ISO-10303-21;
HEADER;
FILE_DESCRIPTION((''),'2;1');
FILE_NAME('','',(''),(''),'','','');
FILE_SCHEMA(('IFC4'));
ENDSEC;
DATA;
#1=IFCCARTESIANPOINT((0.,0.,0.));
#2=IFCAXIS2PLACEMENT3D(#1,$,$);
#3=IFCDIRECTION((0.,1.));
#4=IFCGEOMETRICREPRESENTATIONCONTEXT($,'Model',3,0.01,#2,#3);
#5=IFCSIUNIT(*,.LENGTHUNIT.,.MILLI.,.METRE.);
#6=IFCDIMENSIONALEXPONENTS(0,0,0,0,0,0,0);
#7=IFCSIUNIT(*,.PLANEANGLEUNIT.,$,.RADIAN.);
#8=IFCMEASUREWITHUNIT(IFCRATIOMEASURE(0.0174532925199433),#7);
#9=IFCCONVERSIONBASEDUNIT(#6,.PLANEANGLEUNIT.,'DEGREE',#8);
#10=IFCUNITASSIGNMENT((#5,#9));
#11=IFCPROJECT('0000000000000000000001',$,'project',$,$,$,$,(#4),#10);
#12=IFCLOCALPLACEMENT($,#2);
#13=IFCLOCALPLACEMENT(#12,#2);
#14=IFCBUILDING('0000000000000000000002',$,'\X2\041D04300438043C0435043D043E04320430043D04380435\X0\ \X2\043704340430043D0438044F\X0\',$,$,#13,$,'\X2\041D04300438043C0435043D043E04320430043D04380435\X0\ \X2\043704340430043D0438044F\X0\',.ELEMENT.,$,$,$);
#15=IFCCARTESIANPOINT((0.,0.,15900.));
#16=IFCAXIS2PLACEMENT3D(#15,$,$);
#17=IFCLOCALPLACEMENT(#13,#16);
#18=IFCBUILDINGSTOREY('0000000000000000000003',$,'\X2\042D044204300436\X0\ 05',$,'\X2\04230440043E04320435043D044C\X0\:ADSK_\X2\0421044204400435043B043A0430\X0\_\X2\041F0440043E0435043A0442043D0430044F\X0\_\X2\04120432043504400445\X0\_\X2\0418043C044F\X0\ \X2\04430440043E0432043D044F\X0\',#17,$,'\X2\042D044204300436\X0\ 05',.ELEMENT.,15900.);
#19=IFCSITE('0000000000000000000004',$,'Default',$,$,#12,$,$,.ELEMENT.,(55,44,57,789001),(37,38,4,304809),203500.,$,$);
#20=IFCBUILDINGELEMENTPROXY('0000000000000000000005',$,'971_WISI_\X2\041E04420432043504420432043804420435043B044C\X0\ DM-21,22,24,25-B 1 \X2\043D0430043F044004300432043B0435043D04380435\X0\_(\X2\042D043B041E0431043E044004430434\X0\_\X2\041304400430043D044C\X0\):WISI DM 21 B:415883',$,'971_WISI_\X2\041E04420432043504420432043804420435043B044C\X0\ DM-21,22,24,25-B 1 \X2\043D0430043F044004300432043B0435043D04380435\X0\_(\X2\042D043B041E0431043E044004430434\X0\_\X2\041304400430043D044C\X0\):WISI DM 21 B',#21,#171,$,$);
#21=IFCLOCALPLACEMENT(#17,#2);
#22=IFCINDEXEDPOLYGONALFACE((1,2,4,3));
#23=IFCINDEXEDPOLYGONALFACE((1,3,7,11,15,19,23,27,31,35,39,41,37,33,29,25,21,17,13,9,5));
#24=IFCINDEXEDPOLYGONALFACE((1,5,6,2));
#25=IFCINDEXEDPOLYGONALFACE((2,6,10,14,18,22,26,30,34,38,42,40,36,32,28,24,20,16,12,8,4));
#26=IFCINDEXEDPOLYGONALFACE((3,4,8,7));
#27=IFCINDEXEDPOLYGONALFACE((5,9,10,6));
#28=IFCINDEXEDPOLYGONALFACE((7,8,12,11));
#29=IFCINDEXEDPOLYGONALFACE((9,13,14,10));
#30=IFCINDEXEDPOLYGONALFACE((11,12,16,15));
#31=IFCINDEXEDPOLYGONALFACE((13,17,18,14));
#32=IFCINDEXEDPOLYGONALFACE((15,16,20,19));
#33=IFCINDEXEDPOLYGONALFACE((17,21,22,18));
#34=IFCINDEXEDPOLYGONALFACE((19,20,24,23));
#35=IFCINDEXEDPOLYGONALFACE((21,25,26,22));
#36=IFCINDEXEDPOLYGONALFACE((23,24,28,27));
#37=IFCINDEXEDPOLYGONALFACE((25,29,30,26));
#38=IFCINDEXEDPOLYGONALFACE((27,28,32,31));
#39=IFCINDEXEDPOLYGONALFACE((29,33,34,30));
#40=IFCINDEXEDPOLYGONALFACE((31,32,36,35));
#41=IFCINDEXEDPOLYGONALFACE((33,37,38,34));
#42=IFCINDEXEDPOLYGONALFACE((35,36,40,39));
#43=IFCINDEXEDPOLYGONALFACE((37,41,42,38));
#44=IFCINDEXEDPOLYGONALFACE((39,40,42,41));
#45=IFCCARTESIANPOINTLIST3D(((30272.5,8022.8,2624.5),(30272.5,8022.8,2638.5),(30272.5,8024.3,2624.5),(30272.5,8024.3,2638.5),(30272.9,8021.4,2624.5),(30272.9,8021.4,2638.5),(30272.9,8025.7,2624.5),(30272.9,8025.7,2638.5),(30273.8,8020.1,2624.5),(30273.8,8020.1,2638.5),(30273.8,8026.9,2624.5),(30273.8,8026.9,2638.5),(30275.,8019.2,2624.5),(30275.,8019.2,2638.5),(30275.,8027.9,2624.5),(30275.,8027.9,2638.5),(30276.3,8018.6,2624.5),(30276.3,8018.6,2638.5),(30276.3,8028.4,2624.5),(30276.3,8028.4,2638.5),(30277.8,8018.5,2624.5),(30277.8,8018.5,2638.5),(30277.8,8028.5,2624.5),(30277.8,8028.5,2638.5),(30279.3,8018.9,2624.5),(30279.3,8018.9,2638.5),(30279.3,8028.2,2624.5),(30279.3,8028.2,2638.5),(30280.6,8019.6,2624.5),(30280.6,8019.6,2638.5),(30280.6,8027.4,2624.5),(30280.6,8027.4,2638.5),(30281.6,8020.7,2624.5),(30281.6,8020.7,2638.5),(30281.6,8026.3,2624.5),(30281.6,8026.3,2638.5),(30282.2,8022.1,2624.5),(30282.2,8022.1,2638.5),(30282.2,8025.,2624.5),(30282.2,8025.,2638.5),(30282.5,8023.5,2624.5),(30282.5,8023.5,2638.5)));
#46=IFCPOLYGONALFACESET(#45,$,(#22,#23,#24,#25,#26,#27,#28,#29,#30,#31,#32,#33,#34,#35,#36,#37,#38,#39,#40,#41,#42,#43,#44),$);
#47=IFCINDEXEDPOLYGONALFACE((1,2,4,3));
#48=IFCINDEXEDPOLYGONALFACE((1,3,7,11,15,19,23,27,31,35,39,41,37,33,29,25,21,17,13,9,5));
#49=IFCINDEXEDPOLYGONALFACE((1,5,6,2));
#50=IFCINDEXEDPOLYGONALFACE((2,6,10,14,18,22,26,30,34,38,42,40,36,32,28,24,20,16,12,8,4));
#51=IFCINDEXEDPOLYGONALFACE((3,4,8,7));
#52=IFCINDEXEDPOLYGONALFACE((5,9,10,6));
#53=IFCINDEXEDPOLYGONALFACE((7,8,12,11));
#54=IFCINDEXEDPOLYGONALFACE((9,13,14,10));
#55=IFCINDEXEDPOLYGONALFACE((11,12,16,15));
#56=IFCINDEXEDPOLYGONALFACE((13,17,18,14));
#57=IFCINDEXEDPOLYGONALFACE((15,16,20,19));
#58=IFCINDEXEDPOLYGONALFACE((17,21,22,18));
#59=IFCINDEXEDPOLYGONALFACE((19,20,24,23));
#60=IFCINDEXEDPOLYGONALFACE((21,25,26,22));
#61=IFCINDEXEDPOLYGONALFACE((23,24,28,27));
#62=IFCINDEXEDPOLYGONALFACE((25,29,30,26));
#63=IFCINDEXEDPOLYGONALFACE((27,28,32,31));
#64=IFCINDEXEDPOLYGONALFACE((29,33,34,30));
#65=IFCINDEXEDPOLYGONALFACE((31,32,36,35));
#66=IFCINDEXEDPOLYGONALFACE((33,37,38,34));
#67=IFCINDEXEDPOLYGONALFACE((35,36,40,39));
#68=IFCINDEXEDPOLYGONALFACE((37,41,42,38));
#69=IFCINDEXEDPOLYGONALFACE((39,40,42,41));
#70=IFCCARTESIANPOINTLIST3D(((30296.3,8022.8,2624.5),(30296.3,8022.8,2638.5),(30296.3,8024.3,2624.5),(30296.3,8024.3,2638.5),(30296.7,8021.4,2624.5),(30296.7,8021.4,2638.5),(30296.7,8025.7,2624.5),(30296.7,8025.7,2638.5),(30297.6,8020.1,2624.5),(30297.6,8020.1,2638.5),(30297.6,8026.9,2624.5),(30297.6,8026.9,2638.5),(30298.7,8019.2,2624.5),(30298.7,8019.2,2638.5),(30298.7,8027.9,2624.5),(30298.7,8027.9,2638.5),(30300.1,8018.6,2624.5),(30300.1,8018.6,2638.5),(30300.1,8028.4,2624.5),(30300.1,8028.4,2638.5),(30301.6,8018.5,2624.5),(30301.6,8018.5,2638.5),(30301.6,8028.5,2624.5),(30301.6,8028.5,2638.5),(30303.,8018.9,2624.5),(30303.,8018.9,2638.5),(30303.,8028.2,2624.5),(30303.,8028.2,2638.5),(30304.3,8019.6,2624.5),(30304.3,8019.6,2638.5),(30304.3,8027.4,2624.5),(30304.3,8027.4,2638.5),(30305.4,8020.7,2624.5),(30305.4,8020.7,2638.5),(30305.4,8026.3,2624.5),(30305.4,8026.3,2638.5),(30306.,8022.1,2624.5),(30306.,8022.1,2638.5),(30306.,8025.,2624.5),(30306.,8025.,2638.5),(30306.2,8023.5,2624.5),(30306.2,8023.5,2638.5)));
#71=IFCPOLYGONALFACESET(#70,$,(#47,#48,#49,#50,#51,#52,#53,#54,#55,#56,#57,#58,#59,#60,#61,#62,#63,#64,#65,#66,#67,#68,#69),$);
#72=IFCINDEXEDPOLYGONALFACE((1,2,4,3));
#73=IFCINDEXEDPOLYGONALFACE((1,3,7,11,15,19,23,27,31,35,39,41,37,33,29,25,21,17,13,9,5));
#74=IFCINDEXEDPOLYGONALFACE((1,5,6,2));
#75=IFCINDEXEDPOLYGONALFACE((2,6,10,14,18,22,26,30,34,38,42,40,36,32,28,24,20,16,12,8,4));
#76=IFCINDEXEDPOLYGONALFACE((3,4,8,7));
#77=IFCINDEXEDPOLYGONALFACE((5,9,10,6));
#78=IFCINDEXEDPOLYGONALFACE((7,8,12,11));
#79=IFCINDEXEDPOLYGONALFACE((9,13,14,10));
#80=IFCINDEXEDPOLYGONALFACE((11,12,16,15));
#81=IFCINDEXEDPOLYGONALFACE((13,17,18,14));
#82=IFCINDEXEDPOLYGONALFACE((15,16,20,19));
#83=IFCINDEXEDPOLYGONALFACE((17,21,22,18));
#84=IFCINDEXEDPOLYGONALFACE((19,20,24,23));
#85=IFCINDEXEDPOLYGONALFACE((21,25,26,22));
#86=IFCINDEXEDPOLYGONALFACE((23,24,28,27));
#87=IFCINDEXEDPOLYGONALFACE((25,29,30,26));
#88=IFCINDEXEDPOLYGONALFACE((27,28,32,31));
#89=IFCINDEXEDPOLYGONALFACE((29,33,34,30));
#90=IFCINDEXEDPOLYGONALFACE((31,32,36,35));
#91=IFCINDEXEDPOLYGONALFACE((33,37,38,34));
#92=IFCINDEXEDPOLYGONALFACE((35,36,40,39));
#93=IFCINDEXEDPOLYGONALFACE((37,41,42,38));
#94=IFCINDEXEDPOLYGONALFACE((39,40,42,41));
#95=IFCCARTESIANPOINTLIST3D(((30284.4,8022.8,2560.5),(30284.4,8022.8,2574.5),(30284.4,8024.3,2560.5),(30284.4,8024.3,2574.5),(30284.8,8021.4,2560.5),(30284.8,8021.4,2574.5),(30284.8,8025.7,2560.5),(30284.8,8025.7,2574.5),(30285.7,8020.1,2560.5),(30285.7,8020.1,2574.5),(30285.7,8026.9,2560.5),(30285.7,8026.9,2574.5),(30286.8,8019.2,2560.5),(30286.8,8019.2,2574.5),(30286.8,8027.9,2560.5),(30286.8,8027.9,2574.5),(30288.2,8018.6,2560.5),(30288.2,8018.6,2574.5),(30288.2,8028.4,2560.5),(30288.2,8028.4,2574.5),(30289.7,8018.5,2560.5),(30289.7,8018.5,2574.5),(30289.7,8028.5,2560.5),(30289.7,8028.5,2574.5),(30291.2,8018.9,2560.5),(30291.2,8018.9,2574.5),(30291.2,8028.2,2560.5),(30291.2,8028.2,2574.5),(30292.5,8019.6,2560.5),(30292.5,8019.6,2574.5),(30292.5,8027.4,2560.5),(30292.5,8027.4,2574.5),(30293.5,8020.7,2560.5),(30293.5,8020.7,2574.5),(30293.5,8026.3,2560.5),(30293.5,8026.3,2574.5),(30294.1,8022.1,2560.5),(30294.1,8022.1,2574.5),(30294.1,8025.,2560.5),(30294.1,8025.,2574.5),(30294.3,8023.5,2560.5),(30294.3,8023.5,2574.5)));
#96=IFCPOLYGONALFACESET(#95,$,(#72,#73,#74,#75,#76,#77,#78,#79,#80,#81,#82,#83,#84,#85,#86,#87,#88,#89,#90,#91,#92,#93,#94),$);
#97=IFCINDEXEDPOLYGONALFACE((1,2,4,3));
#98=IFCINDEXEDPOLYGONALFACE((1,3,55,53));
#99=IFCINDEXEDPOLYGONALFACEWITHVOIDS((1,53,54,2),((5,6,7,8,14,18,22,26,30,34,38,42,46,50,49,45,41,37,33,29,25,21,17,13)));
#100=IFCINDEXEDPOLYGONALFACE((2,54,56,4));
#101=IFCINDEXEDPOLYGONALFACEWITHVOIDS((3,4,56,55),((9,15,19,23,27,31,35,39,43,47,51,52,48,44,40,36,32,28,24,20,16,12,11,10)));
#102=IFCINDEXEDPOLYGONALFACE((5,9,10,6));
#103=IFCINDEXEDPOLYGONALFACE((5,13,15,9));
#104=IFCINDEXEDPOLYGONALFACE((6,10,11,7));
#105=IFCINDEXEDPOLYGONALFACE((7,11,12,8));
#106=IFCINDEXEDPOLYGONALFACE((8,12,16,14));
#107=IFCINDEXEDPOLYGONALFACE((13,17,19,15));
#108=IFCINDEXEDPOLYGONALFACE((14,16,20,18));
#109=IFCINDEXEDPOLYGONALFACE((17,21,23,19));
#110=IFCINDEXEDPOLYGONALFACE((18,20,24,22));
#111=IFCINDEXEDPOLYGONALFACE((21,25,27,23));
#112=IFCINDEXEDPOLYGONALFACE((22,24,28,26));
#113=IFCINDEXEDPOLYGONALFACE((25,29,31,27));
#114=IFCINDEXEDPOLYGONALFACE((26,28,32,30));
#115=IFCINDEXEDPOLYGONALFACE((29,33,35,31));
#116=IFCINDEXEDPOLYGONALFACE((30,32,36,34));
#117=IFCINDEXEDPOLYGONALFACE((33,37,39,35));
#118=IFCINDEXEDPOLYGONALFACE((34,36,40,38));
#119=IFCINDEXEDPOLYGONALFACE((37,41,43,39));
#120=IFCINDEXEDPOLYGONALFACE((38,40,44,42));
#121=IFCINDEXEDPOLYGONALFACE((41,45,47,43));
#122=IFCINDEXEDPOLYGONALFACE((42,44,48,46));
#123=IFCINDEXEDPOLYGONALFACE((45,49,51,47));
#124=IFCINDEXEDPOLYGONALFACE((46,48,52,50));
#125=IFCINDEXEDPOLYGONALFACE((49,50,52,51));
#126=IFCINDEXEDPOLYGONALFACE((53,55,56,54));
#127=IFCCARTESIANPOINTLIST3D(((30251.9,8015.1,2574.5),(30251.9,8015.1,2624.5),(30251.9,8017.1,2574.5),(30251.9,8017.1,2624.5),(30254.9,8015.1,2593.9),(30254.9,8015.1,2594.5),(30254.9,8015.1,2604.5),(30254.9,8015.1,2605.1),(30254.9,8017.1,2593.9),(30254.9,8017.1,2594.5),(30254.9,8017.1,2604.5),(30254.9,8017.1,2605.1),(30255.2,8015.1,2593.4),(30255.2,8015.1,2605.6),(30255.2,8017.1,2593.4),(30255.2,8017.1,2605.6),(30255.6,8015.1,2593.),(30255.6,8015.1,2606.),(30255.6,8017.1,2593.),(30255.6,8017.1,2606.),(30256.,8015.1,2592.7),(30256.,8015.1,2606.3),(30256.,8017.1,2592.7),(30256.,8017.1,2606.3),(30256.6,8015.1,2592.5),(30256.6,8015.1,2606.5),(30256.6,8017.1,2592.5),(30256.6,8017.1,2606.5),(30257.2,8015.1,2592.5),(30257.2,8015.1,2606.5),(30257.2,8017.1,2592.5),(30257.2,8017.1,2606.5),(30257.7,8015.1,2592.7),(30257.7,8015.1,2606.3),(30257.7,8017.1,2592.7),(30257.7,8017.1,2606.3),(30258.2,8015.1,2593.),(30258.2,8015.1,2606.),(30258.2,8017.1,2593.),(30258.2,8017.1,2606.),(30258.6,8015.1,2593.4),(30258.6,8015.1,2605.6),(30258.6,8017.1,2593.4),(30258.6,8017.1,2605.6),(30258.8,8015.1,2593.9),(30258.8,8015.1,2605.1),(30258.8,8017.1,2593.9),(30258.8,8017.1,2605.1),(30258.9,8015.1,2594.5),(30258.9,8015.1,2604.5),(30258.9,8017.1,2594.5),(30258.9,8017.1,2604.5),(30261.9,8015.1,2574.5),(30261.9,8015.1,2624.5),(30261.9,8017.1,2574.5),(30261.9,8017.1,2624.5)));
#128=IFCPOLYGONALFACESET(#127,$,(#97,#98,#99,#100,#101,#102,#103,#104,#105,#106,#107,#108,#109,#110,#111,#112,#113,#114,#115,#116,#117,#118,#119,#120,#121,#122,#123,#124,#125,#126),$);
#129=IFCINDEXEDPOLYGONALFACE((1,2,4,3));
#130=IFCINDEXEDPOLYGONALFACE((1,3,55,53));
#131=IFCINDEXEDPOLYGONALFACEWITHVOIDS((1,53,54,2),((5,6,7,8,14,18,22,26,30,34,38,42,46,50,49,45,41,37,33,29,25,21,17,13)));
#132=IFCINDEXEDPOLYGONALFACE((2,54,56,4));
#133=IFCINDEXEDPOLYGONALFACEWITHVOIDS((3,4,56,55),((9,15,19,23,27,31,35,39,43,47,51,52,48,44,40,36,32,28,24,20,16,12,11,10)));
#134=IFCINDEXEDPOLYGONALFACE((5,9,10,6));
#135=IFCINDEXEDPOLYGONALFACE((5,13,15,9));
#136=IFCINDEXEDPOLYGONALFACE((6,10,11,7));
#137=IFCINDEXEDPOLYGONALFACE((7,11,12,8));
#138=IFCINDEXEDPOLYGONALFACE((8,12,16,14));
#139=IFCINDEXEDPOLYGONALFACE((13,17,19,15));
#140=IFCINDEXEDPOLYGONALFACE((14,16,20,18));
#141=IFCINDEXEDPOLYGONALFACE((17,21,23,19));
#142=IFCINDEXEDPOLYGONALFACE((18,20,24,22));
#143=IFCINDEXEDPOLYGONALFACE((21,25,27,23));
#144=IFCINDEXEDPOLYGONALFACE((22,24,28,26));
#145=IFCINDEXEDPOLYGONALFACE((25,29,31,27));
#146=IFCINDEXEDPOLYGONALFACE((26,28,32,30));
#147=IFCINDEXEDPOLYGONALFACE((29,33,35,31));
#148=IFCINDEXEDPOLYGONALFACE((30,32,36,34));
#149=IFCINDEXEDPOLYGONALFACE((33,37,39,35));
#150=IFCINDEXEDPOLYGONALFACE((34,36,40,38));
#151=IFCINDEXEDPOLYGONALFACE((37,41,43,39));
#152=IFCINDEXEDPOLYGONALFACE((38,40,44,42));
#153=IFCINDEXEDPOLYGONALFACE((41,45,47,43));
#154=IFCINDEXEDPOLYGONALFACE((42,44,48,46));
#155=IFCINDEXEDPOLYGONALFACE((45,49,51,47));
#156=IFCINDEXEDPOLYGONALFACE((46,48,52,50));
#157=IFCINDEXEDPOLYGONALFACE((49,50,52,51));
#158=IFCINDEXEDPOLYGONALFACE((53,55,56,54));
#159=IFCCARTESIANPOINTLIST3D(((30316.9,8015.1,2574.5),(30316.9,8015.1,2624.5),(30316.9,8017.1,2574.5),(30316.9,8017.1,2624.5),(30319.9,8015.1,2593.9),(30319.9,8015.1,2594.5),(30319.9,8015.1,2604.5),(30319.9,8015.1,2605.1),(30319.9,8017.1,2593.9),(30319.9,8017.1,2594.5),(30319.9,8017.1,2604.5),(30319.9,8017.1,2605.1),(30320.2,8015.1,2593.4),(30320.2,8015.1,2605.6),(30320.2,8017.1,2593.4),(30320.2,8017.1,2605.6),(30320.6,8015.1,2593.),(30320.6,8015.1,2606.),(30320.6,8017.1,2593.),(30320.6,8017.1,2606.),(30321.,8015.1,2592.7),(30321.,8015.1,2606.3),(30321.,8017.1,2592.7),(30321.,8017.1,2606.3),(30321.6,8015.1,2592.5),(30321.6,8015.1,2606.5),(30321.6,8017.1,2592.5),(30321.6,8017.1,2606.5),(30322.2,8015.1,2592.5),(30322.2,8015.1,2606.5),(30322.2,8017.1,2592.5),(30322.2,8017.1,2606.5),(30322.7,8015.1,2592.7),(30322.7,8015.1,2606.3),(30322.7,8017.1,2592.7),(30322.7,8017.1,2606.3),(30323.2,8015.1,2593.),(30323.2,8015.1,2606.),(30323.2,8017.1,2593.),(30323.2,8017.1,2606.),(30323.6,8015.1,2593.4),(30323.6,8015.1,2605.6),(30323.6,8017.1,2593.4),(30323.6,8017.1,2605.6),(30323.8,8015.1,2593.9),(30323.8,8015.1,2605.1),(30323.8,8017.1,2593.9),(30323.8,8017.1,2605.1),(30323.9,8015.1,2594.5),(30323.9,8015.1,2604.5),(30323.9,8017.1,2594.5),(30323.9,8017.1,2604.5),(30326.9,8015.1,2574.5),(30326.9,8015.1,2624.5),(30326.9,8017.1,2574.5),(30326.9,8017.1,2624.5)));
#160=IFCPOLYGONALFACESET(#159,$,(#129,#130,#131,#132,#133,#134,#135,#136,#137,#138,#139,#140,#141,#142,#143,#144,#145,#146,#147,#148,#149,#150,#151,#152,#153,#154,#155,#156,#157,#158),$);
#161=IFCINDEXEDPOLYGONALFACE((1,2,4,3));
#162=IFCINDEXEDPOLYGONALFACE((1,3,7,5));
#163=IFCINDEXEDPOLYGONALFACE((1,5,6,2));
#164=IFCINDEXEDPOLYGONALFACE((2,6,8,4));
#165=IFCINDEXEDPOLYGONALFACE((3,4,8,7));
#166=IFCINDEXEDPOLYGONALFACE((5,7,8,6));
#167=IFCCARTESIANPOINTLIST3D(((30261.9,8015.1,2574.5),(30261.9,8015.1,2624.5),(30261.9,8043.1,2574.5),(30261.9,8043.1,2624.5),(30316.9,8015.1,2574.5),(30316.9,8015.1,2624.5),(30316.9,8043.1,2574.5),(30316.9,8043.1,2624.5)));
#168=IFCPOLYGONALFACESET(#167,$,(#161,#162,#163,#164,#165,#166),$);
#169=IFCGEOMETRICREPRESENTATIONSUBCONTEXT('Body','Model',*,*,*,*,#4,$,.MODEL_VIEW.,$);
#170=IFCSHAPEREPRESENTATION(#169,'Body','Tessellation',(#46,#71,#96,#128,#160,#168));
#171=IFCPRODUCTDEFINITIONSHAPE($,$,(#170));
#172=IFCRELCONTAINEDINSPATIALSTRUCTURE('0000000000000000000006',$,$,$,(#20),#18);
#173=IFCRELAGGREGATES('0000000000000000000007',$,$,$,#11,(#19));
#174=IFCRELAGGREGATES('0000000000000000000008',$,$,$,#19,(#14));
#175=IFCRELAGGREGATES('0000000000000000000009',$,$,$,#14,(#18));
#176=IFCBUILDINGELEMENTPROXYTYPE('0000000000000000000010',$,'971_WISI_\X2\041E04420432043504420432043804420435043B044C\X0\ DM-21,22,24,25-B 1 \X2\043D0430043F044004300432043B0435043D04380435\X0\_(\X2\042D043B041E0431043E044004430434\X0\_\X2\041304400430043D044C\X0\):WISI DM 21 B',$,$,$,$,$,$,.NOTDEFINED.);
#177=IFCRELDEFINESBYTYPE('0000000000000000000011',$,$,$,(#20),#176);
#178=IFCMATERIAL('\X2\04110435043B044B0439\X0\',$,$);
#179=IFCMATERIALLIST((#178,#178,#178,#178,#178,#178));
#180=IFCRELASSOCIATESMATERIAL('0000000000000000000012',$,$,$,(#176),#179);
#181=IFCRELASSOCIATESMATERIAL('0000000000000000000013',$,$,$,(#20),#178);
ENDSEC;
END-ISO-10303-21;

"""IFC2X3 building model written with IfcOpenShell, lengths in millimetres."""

from ifc_helpers import new_model, entity, si_unit, converted_unit, direction, frame, frame_2d, origin, place, context, subcontext, project, spatial, polyline, circle_curve, parameter, trimmed, segment, composite_curve, rectangle, circle, outline, extrude, source, transform, mapped, material, material_list, type_object, type_shapes, element, save


model = new_model("IFC2X3")

# Units and contexts
model_context = context("Model", 3, precision=0.01, world=origin(), true_north=direction((0.0, 1.0)))
body_context = subcontext(model_context, "Body", "Model", "MODEL_VIEW")
ifc_project = project(units=[si_unit("LENGTHUNIT", "METRE", prefix="MILLI"), converted_unit("PLANEANGLEUNIT", "DEGREE", entity("IfcRatioMeasure", 0.0174532925199433), si_unit("PLANEANGLEUNIT", "RADIAN"), dimensions=[0, 0, 0, 0, 0, 0, 0])], contexts=[model_context])

# Site, building, storey
site_placement = place(None, frame((0.0, 0.0, 0.0)))
site = spatial("IfcSite", under=ifc_project, at=site_placement, Name="Default", CompositionType="ELEMENT", RefLatitude=(55, 44, 57, 789001), RefLongitude=(37, 38, 4, 304809), RefElevation=203500.0)
building_placement = place(site_placement, origin())
building = spatial("IfcBuilding", under=site, at=building_placement, Name="Наименование здания", LongName="Наименование здания", CompositionType="ELEMENT")
storey_placement = place(building_placement, frame((0.0, 0.0, 15900.0)))
storey = spatial("IfcBuildingStorey", under=building, at=storey_placement, Name="Этаж 05", ObjectType="Уровень:ADSK_Стрелка_Проектная_Вверх_Имя уровня", LongName="Этаж 05", CompositionType="ELEMENT", Elevation=15900.0)

# Building element proxy
ifc_material = material(Name="Белый")
ifc_material_list = material_list([ifc_material, ifc_material, ifc_material, ifc_material, ifc_material, ifc_material])
building_element_proxy_type = type_object("IfcBuildingElementProxyType", Name="971_WISI_Ответвитель DM-21,22,24,25-B 1 направление_(ЭлОборуд_Грань):WISI DM 21 B", PredefinedType="NOTDEFINED", material=ifc_material_list)
shared_shape = source(origin(), body_context, "Body", "SweptSolid", [
    extrude(circle(Radius=5.0, at=frame_2d((0.0, 0.0), x_axis=(1.0, 0.0))), frame((11.9, 25.0, 8.4), z_axis=(0.0, 1.0, 0.0), x_axis=(-1.0, 0.0, 0.0)), (0.0, 0.0, 1.0), 14.0),
    extrude(circle(Radius=5.0, at=frame_2d((0.0, 0.0), x_axis=(1.0, 0.0))), frame((-11.8, 25.0, 8.4), z_axis=(0.0, 1.0, 0.0), x_axis=(-1.0, 0.0, 0.0)), (0.0, 0.0, 1.0), 14.0),
    extrude(circle(Radius=5.0, at=frame_2d((0.0, 0.0), x_axis=(1.0, 0.0))), frame((0.0, -39.0, 8.4), z_axis=(0.0, 1.0, 0.0), x_axis=(-1.0, 0.0, 0.0)), (0.0, 0.0, 1.0), 14.0),
    extrude(outline(polyline([(-5.0, -25.0), (5.0, -25.0), (5.0, 25.0), (-5.0, 25.0), (-5.0, -25.0)]), holes=[composite_curve([segment(polyline([(2.0, 5.0), (2.0, -5.0)]), True, "CONTINUOUS"), segment(trimmed(circle_curve(frame_2d((0.0, -5.0), x_axis=(-1.0, 0.0)), 2.0), [parameter(0.0)], [parameter(180.0)], True, "PARAMETER"), False, "CONTINUOUS"), segment(polyline([(-2.0, -5.0), (-2.0, 5.0)]), True, "CONTINUOUS"), segment(trimmed(circle_curve(frame_2d((0.0, 5.0), x_axis=(-1.0, 0.0)), 2.0), [parameter(180.0)], [parameter(0.0)], True, "PARAMETER"), False, "CONTINUOUS")], self_intersect=False)]), frame((32.5, 0.0, 0.0), z_axis=(0.0, 0.0, 1.0), x_axis=(-1.0, 0.0, 0.0)), (0.0, 0.0, 1.0), 2.0),
    extrude(outline(polyline([(-5.0, -25.0), (5.0, -25.0), (5.0, 25.0), (-5.0, 25.0), (-5.0, -25.0)]), holes=[composite_curve([segment(polyline([(-2.0, -5.0), (-2.0, 5.0)]), True, "CONTINUOUS"), segment(trimmed(circle_curve(frame_2d((0.0, 5.0), x_axis=(-1.0, 0.0)), 2.0), [parameter(180.0)], [parameter(0.0)], True, "PARAMETER"), False, "CONTINUOUS"), segment(polyline([(2.0, 5.0), (2.0, -5.0)]), True, "CONTINUOUS"), segment(trimmed(circle_curve(frame_2d((0.0, -5.0), x_axis=(-1.0, 0.0)), 2.0), [parameter(0.0)], [parameter(180.0)], True, "PARAMETER"), False, "CONTINUOUS")], self_intersect=False)]), frame((-32.5, 0.0, 0.0), z_axis=(0.0, 0.0, 1.0), x_axis=(-1.0, 0.0, 0.0)), (0.0, 0.0, 1.0), 2.0),
    extrude(rectangle(XDim=55.0, YDim=50.0, at=frame_2d((0.0, 0.0), x_axis=(1.0, 0.0))), frame((0.0, 0.0, 0.0), z_axis=(0.0, 0.0, 1.0), x_axis=(-1.0, 0.0, 0.0)), (0.0, 0.0, 1.0), 28.0),
])
type_shapes(building_element_proxy_type, [shared_shape])
for number, where, z_axis, x_axis, name in (
    (1, (30289.4, 8015.1, 2599.5), (0.0, 1.0, 0.0), (-1.0, 0.0, 0.0), "971_WISI_Ответвитель DM-21,22,24,25-B 1 направление_(ЭлОборуд_Грань):WISI DM 21 B:415883"),
):
    element("IfcBuildingElementProxy", number, at=place(storey_placement, frame(where, z_axis=z_axis, x_axis=x_axis)), inside=storey, type_object=building_element_proxy_type, material=ifc_material, Name=name, ObjectType="971_WISI_Ответвитель DM-21,22,24,25-B 1 направление_(ЭлОборуд_Грань):WISI DM 21 B", context=body_context, shape_type="MappedRepresentation", body=[
        mapped(shared_shape, transform((0.0, 0.0, 0.0), scale=1.0)),
    ])

save(model, "model.ifc")
